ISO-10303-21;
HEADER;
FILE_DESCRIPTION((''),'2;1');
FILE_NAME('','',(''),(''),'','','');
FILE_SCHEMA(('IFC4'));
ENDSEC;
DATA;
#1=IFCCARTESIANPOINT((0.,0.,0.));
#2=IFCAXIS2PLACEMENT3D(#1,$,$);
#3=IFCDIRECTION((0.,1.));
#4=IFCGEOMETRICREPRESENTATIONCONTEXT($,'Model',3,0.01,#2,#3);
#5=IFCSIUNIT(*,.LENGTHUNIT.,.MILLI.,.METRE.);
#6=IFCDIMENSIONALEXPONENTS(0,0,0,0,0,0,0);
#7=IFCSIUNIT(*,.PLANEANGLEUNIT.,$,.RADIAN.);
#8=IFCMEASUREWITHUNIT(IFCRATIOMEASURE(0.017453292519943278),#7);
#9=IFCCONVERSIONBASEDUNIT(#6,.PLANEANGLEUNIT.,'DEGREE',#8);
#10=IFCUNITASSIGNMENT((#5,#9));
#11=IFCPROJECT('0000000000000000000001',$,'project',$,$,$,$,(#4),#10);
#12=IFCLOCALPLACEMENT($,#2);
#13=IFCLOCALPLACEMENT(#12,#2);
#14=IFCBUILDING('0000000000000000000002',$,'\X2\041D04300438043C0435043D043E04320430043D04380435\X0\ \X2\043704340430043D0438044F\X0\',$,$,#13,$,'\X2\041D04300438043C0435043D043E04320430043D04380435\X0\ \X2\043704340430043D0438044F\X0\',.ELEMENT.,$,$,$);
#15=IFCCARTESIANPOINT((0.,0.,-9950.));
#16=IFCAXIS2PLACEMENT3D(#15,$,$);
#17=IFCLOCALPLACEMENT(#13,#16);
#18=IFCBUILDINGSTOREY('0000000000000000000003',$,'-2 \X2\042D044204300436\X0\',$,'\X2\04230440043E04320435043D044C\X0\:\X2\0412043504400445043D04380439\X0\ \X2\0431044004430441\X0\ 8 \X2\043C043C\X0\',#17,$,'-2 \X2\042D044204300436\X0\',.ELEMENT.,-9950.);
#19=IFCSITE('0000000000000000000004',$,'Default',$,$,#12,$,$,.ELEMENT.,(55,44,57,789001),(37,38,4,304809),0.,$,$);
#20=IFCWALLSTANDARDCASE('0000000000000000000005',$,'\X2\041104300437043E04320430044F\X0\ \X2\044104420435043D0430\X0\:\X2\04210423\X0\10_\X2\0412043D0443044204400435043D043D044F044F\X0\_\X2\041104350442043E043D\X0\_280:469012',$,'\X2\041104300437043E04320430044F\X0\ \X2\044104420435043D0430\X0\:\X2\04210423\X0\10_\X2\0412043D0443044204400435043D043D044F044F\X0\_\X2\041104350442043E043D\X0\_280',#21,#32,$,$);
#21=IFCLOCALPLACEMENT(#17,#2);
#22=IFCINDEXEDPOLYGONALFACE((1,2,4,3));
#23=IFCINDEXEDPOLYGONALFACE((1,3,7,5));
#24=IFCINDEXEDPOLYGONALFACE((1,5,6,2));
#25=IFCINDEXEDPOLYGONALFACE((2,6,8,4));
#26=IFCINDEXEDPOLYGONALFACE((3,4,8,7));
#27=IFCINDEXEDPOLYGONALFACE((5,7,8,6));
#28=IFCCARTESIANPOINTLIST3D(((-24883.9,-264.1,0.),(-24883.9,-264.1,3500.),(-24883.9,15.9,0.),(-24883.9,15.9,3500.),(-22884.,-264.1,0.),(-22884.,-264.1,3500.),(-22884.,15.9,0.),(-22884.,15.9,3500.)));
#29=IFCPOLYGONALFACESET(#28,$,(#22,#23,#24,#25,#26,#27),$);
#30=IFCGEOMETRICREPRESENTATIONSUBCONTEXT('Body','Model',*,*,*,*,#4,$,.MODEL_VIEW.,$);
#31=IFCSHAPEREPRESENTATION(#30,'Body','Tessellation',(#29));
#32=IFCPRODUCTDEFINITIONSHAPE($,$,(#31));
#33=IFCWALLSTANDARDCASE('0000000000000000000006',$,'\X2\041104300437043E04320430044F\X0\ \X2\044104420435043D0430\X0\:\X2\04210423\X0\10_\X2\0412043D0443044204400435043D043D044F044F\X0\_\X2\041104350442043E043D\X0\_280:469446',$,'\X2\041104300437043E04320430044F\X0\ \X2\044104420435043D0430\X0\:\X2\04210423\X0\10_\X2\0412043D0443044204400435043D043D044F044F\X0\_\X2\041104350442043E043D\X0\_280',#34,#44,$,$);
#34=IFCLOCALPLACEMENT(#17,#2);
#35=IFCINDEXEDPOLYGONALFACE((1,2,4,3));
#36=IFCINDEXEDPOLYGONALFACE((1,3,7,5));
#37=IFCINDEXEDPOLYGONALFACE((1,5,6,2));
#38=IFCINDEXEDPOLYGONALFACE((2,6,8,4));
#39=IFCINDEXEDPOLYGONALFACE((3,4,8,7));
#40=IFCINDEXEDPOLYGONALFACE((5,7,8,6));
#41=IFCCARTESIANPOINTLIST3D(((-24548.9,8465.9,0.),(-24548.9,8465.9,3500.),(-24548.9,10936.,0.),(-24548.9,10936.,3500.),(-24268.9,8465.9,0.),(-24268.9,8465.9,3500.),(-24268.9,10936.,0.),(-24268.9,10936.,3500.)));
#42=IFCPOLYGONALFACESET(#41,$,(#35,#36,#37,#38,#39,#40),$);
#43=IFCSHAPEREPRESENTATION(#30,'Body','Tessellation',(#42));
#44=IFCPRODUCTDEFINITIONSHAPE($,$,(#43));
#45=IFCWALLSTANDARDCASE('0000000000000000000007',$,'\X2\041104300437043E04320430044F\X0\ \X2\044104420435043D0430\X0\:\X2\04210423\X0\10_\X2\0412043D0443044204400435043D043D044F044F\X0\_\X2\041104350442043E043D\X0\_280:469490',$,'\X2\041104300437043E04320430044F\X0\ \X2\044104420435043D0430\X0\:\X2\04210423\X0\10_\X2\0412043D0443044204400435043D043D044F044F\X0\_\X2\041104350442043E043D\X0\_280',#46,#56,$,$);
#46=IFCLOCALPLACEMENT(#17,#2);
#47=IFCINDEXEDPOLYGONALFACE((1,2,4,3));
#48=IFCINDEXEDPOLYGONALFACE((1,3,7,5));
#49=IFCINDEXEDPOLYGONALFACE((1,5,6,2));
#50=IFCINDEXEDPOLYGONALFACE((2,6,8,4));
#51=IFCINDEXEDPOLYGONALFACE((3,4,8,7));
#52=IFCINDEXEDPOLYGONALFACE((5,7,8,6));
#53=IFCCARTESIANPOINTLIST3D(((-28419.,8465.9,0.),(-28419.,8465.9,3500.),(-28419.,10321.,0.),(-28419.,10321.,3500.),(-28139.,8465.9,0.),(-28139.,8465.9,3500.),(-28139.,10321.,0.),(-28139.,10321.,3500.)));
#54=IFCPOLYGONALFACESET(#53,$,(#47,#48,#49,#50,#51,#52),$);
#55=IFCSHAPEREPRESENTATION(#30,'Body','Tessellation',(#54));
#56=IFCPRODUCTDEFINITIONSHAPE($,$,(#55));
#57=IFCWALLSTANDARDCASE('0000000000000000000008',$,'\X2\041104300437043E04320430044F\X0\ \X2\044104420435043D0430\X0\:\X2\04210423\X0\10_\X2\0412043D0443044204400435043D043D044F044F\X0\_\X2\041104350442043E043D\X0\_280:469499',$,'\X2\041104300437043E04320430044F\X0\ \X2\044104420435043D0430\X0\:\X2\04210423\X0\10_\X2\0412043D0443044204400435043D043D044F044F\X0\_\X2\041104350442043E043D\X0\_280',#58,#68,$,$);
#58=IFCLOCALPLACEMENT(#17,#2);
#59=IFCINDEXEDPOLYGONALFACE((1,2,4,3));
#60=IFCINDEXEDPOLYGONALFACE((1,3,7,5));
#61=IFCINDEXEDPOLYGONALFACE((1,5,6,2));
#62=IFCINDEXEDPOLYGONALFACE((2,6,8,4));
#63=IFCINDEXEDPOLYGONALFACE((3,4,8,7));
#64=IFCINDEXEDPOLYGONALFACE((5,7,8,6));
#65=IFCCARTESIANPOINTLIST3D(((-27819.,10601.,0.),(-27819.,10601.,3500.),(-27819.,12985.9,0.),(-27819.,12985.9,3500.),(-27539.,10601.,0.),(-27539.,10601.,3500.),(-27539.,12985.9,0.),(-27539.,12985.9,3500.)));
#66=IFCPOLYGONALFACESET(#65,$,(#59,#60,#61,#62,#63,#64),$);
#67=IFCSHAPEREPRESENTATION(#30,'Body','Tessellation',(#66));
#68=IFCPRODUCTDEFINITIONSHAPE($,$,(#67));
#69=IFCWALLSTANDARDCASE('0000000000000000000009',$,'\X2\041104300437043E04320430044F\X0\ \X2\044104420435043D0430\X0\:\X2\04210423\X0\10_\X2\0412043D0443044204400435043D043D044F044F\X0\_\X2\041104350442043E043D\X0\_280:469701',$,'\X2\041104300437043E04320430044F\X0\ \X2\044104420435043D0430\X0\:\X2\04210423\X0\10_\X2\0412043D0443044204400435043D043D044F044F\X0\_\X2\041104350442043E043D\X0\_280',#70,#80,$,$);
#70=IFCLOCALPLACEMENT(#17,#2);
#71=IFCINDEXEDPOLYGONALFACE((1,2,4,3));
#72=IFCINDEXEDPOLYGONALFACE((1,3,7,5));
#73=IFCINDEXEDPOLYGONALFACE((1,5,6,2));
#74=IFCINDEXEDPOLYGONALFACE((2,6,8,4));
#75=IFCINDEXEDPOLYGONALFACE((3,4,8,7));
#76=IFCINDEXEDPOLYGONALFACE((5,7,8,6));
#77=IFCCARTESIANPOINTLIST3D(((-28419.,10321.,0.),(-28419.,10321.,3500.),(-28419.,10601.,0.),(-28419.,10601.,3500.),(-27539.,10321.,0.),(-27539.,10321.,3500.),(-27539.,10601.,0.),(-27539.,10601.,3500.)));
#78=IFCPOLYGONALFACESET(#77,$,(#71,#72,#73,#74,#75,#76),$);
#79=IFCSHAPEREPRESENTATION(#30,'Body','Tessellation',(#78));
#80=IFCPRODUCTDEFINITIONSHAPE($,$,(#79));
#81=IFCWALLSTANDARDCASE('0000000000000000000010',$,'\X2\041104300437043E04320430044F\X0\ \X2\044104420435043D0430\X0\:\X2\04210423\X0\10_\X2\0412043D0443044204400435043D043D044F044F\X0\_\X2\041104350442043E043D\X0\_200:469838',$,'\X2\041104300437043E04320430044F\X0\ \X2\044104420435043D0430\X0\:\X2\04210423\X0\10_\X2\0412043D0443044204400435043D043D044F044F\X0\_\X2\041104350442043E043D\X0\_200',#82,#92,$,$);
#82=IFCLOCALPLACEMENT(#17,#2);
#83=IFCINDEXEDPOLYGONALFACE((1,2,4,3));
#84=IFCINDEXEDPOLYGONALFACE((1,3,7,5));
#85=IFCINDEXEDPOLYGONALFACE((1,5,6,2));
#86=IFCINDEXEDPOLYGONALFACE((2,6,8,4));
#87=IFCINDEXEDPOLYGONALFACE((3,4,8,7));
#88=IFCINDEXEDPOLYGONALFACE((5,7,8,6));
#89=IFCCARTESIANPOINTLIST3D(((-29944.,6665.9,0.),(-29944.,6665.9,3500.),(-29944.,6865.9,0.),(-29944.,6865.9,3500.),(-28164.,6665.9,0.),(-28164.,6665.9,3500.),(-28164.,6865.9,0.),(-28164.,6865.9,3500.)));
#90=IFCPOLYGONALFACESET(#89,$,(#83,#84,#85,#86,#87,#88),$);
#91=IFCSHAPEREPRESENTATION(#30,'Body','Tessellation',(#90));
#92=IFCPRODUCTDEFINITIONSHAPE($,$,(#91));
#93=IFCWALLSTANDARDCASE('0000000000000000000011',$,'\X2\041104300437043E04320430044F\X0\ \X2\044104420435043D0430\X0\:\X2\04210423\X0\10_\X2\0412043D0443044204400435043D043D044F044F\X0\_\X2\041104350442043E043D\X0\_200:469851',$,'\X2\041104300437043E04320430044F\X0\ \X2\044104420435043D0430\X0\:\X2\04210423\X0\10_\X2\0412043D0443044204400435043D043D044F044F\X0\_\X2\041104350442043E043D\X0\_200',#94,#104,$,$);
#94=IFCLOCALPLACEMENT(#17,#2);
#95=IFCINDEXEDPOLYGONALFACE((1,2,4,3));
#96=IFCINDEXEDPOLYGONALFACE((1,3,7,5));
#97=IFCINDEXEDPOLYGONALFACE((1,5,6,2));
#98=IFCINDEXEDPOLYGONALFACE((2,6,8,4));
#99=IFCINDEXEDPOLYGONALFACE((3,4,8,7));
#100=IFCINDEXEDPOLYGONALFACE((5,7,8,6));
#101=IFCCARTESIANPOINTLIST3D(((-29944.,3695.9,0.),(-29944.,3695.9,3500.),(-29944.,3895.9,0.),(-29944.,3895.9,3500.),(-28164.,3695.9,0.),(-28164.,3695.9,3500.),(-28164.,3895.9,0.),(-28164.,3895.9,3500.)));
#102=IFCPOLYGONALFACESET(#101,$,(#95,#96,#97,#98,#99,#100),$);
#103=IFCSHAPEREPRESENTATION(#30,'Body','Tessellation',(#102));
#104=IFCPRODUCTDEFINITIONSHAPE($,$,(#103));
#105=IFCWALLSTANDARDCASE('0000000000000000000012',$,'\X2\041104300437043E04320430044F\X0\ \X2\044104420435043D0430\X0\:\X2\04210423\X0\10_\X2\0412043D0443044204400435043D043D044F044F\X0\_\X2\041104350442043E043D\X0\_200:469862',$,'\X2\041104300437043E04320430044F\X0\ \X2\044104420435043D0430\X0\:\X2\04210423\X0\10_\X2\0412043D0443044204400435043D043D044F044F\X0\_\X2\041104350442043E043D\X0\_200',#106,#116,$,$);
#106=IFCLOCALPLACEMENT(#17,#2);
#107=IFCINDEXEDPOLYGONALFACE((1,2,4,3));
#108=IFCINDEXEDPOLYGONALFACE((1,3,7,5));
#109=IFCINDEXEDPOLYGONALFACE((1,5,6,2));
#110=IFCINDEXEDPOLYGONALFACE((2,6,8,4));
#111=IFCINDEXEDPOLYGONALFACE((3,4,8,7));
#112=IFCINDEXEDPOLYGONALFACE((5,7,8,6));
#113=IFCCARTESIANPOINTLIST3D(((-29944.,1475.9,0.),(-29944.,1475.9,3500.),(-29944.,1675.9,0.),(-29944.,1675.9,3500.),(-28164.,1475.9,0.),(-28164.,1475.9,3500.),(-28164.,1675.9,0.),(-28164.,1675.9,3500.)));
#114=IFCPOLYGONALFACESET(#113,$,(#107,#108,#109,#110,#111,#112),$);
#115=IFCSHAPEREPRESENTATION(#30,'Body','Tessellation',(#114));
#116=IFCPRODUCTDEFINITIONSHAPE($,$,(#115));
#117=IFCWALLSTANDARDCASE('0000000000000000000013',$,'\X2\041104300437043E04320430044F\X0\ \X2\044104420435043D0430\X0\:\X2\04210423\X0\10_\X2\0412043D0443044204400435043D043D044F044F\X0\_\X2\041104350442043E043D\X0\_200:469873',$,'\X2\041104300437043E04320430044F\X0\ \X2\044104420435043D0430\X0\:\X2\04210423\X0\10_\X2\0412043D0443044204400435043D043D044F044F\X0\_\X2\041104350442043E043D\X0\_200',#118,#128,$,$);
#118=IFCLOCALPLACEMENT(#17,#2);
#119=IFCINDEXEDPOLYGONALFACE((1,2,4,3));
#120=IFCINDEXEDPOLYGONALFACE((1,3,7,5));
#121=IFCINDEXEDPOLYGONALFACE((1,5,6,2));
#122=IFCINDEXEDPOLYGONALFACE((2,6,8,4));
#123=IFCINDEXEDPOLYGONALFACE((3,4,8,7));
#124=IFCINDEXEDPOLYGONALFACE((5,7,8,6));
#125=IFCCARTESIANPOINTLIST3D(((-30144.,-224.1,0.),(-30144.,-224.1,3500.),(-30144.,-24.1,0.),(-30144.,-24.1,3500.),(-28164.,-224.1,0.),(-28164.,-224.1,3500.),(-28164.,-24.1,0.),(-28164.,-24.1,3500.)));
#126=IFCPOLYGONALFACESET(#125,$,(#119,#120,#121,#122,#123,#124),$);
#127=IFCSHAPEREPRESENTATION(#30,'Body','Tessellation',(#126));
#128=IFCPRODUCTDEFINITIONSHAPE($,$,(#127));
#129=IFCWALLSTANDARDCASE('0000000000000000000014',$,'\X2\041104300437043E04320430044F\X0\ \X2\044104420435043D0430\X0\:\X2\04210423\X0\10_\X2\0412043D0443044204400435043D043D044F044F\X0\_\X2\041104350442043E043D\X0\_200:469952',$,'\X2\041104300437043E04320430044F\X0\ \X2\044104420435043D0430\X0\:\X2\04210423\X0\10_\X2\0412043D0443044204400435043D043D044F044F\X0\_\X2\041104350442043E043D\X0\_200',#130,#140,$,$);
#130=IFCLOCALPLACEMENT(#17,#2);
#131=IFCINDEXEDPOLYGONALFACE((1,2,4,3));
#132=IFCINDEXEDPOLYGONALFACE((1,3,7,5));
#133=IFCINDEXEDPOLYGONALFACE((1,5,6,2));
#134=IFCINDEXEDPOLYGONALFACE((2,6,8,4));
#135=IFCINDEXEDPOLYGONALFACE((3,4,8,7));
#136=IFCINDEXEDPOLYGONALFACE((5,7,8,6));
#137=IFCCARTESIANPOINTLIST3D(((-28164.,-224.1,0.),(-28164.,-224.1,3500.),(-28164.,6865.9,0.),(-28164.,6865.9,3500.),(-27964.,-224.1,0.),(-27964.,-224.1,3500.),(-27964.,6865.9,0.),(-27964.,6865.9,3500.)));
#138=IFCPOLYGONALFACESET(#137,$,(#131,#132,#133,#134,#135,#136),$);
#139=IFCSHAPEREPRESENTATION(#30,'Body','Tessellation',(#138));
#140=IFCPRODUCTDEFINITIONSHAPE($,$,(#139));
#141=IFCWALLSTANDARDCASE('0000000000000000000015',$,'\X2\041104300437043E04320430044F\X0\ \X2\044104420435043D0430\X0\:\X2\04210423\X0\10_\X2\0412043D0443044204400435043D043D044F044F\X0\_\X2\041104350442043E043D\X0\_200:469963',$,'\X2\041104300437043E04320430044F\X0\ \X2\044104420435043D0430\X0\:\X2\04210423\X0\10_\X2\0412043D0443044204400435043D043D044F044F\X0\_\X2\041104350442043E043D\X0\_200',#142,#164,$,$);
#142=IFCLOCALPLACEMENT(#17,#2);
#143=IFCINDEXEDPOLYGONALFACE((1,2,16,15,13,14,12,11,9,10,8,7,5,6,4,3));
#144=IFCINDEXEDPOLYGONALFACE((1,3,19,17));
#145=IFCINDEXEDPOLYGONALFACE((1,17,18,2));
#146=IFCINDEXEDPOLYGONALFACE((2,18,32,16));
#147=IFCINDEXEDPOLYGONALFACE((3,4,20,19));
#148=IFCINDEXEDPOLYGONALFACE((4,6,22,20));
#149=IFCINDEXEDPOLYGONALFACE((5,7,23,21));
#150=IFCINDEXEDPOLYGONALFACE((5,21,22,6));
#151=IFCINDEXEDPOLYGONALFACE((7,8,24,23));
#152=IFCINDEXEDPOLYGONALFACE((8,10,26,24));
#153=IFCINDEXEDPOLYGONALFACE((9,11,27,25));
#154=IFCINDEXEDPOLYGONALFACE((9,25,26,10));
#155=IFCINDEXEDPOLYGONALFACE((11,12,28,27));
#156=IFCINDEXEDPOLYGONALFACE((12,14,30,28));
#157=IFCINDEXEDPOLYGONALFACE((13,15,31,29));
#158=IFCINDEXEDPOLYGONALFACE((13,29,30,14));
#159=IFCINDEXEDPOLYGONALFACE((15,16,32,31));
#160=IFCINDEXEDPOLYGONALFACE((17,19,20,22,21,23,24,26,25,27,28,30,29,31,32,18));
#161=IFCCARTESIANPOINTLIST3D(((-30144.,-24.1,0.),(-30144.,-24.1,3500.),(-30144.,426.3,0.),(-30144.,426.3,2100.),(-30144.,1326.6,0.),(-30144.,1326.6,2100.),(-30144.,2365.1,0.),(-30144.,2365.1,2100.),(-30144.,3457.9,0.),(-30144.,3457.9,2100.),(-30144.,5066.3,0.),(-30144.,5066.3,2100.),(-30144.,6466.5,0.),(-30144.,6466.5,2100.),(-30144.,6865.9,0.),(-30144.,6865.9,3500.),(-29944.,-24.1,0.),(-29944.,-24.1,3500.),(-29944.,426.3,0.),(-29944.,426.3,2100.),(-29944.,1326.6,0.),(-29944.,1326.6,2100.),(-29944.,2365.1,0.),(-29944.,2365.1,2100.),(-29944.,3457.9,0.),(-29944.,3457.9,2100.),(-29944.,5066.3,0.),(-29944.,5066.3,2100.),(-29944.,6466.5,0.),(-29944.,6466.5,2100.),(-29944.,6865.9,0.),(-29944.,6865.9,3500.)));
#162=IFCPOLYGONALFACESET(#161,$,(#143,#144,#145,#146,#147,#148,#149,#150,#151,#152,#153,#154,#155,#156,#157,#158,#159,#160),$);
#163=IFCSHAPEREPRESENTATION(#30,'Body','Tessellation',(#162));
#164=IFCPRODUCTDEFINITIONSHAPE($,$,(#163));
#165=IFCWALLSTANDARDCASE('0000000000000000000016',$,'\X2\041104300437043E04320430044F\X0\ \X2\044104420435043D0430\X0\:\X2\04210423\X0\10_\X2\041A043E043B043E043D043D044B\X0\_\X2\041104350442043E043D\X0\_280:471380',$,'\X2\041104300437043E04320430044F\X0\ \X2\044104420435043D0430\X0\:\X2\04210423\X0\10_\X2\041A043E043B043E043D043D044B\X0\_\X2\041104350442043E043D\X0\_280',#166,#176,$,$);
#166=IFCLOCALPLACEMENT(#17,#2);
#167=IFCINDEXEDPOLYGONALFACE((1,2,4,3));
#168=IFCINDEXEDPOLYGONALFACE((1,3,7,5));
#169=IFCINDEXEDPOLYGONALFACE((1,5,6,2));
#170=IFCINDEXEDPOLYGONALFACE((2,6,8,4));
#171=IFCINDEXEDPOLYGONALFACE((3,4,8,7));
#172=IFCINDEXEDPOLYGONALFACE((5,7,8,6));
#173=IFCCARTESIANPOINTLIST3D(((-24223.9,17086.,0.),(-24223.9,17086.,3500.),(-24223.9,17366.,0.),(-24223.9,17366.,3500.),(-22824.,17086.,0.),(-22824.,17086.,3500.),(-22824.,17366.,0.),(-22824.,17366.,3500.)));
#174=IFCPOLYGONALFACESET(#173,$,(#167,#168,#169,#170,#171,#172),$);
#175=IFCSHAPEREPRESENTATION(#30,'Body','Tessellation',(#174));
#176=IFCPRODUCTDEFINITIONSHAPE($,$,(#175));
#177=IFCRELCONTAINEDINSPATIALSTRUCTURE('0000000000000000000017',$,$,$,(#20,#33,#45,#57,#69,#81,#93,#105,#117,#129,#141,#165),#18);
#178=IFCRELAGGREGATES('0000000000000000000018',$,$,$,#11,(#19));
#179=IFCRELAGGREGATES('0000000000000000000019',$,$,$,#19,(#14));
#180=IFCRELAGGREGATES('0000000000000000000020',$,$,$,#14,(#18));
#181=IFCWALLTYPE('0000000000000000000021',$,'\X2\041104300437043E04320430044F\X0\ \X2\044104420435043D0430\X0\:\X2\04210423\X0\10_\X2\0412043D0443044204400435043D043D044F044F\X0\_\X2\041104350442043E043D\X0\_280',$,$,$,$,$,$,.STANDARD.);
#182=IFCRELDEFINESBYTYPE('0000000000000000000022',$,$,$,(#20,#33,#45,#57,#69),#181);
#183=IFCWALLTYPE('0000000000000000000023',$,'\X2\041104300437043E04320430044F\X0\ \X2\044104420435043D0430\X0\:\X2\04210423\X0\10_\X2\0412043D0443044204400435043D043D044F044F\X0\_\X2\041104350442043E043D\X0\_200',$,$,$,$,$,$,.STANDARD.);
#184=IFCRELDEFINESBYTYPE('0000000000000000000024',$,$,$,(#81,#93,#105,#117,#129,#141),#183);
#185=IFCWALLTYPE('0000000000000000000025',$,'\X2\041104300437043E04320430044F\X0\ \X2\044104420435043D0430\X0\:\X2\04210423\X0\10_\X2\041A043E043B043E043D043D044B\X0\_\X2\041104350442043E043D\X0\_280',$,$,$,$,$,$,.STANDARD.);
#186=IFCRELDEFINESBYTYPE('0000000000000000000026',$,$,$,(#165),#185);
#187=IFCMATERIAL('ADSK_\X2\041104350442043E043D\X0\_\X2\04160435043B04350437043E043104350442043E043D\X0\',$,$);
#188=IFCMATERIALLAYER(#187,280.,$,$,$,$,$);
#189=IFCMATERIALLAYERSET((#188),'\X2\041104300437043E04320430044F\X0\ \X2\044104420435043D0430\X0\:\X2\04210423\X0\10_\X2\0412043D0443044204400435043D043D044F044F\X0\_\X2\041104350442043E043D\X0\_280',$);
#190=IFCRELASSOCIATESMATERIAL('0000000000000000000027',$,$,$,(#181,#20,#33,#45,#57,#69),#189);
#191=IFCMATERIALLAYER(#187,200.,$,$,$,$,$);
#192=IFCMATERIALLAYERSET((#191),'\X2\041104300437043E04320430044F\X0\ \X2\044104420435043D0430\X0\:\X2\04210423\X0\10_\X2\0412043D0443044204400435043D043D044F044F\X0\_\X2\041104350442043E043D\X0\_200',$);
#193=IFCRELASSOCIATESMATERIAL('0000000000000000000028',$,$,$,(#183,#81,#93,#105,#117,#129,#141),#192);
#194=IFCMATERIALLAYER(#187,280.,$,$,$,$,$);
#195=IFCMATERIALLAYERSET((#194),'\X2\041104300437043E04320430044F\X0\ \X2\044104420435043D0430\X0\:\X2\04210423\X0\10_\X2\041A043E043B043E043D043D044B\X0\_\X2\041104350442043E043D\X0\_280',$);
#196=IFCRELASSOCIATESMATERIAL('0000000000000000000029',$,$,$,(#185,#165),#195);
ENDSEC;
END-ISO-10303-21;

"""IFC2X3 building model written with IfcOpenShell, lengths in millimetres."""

from ifc_helpers import new_model, entity, si_unit, converted_unit, direction, frame, frame_2d, origin, place, context, subcontext, project, spatial, rectangle, extrude, material, layer, layer_set, layer_usage, type_object, element, save


model = new_model("IFC2X3")

# Units and contexts
model_context = context("Model", 3, precision=0.01, world=origin(), true_north=direction((0.0, 1.0)))
body_context = subcontext(model_context, "Body", "Model", "MODEL_VIEW")
ifc_project = project(units=[si_unit("LENGTHUNIT", "METRE", prefix="MILLI"), converted_unit("PLANEANGLEUNIT", "DEGREE", entity("IfcRatioMeasure", 0.017453292519943278), si_unit("PLANEANGLEUNIT", "RADIAN"), dimensions=[0, 0, 0, 0, 0, 0, 0])], contexts=[model_context])

# Site, building, storey
site_placement = place(None, origin())
site = spatial("IfcSite", under=ifc_project, at=site_placement, Name="Default", CompositionType="ELEMENT", RefLatitude=(55, 44, 57, 789001), RefLongitude=(37, 38, 4, 304809), RefElevation=0.0)
building_placement = place(site_placement, origin())
building = spatial("IfcBuilding", under=site, at=building_placement, Name="Наименование здания", LongName="Наименование здания", CompositionType="ELEMENT")
storey_placement = place(building_placement, frame((0.0, 0.0, -9950.0)))
storey = spatial("IfcBuildingStorey", under=building, at=storey_placement, Name="-2 Этаж", ObjectType="Уровень:Верхний брус 8 мм", LongName="-2 Этаж", CompositionType="ELEMENT", Elevation=-9950.0)

# Walls
ifc_material_1 = material(Name="ADSK_Бетон_Железобетон")
ifc_layer_1 = layer(ifc_material_1, 280.0)
ifc_layer_set_1 = layer_set([ifc_layer_1], Name="Базовая стена:СУ10_Внутренняя_Бетон_280")
ifc_layer_usage_1 = layer_usage(ifc_layer_set_1, "AXIS2", "NEGATIVE", 140.0)
wall_type_1 = type_object("IfcWallType", Name="Базовая стена:СУ10_Внутренняя_Бетон_280", PredefinedType="STANDARD", material=ifc_layer_set_1)
wall_1_placement = place(storey_placement, frame((-22884.0, -124.1, 0.0), z_axis=(0.0, 0.0, 1.0), x_axis=(-1.0, 0.0, 0.0)))
element("IfcWallStandardCase", 1, at=wall_1_placement, inside=storey, type_object=wall_type_1, material=ifc_layer_usage_1, Name="Базовая стена:СУ10_Внутренняя_Бетон_280:469012", ObjectType="Базовая стена:СУ10_Внутренняя_Бетон_280", context=body_context, shape_type="SweptSolid", body=[
    extrude(rectangle(XDim=2000.0, YDim=280.0, at=frame_2d((1000.0, 0.0), x_axis=(-1.0, 0.0))), origin(), (0.0, 0.0, 1.0), 3500.0),
])
wall_2_placement = place(storey_placement, frame((-24408.9, 10936.0, 0.0), z_axis=(0.0, 0.0, 1.0), x_axis=(0.0, -1.0, 0.0)))
element("IfcWallStandardCase", 2, at=wall_2_placement, inside=storey, type_object=wall_type_1, material=ifc_layer_usage_1, Name="Базовая стена:СУ10_Внутренняя_Бетон_280:469446", ObjectType="Базовая стена:СУ10_Внутренняя_Бетон_280", context=body_context, shape_type="SweptSolid", body=[
    extrude(rectangle(XDim=2470.0, YDim=280.0, at=frame_2d((1235.0, 0.0), x_axis=(-1.0, 0.0))), origin(), (0.0, 0.0, 1.0), 3500.0),
])
wall_3_placement = place(storey_placement, frame((-28279.0, 10321.0, 0.0), z_axis=(0.0, 0.0, 1.0), x_axis=(0.0, -1.0, 0.0)))
element("IfcWallStandardCase", 3, at=wall_3_placement, inside=storey, type_object=wall_type_1, material=ifc_layer_usage_1, Name="Базовая стена:СУ10_Внутренняя_Бетон_280:469490", ObjectType="Базовая стена:СУ10_Внутренняя_Бетон_280", context=body_context, shape_type="SweptSolid", body=[
    extrude(rectangle(XDim=1855.0, YDim=280.0, at=frame_2d((927.5, 0.0), x_axis=(-1.0, 0.0))), origin(), (0.0, 0.0, 1.0), 3500.0),
])
wall_4_placement = place(storey_placement, frame((-27679.0, 12985.9, 0.0), z_axis=(0.0, 0.0, 1.0), x_axis=(0.0, -1.0, 0.0)))
element("IfcWallStandardCase", 4, at=wall_4_placement, inside=storey, type_object=wall_type_1, material=ifc_layer_usage_1, Name="Базовая стена:СУ10_Внутренняя_Бетон_280:469499", ObjectType="Базовая стена:СУ10_Внутренняя_Бетон_280", context=body_context, shape_type="SweptSolid", body=[
    extrude(rectangle(XDim=2384.9, YDim=280.0, at=frame_2d((1192.5, 0.0), x_axis=(-1.0, 0.0))), origin(), (0.0, 0.0, 1.0), 3500.0),
])
wall_5_placement = place(storey_placement, frame((-27539.0, 10461.0, 0.0), z_axis=(0.0, 0.0, 1.0), x_axis=(-1.0, 0.0, 0.0)))
element("IfcWallStandardCase", 5, at=wall_5_placement, inside=storey, type_object=wall_type_1, material=ifc_layer_usage_1, Name="Базовая стена:СУ10_Внутренняя_Бетон_280:469701", ObjectType="Базовая стена:СУ10_Внутренняя_Бетон_280", context=body_context, shape_type="SweptSolid", body=[
    extrude(rectangle(XDim=880.0, YDim=280.0, at=frame_2d((440.0, 0.0), x_axis=(-1.0, 0.0))), origin(), (0.0, 0.0, 1.0), 3500.0),
])
ifc_layer_2 = layer(ifc_material_1, 200.0)
ifc_layer_set_2 = layer_set([ifc_layer_2], Name="Базовая стена:СУ10_Внутренняя_Бетон_200")
ifc_layer_usage_2 = layer_usage(ifc_layer_set_2, "AXIS2", "NEGATIVE", 100.0)
wall_type_2 = type_object("IfcWallType", Name="Базовая стена:СУ10_Внутренняя_Бетон_200", PredefinedType="STANDARD", material=ifc_layer_set_2)
wall_6_placement = place(storey_placement, frame((-28164.0, 6765.9, 0.0), z_axis=(0.0, 0.0, 1.0), x_axis=(-1.0, 0.0, 0.0)))
element("IfcWallStandardCase", 6, at=wall_6_placement, inside=storey, type_object=wall_type_2, material=ifc_layer_usage_2, Name="Базовая стена:СУ10_Внутренняя_Бетон_200:469838", ObjectType="Базовая стена:СУ10_Внутренняя_Бетон_200", context=body_context, shape_type="SweptSolid", body=[
    extrude(rectangle(XDim=1780.0, YDim=200.0, at=frame_2d((890.0, 0.0), x_axis=(-1.0, 0.0))), origin(), (0.0, 0.0, 1.0), 3500.0),
])
wall_7_placement = place(storey_placement, frame((-28164.0, 3795.9, 0.0), z_axis=(0.0, 0.0, 1.0), x_axis=(-1.0, 0.0, 0.0)))
element("IfcWallStandardCase", 7, at=wall_7_placement, inside=storey, type_object=wall_type_2, material=ifc_layer_usage_2, Name="Базовая стена:СУ10_Внутренняя_Бетон_200:469851", ObjectType="Базовая стена:СУ10_Внутренняя_Бетон_200", context=body_context, shape_type="SweptSolid", body=[
    extrude(rectangle(XDim=1780.0, YDim=200.0, at=frame_2d((890.0, 0.0), x_axis=(-1.0, 0.0))), origin(), (0.0, 0.0, 1.0), 3500.0),
])
wall_8_placement = place(storey_placement, frame((-28164.0, 1575.9, 0.0), z_axis=(0.0, 0.0, 1.0), x_axis=(-1.0, 0.0, 0.0)))
element("IfcWallStandardCase", 8, at=wall_8_placement, inside=storey, type_object=wall_type_2, material=ifc_layer_usage_2, Name="Базовая стена:СУ10_Внутренняя_Бетон_200:469862", ObjectType="Базовая стена:СУ10_Внутренняя_Бетон_200", context=body_context, shape_type="SweptSolid", body=[
    extrude(rectangle(XDim=1780.0, YDim=200.0, at=frame_2d((890.0, 0.0), x_axis=(-1.0, 0.0))), origin(), (0.0, 0.0, 1.0), 3500.0),
])
wall_9_placement = place(storey_placement, frame((-28164.0, -124.1, 0.0), z_axis=(0.0, 0.0, 1.0), x_axis=(-1.0, 0.0, 0.0)))
element("IfcWallStandardCase", 9, at=wall_9_placement, inside=storey, type_object=wall_type_2, material=ifc_layer_usage_2, Name="Базовая стена:СУ10_Внутренняя_Бетон_200:469873", ObjectType="Базовая стена:СУ10_Внутренняя_Бетон_200", context=body_context, shape_type="SweptSolid", body=[
    extrude(rectangle(XDim=1980.0, YDim=200.0, at=frame_2d((990.0, 0.0), x_axis=(-1.0, 0.0))), origin(), (0.0, 0.0, 1.0), 3500.0),
])
wall_10_placement = place(storey_placement, frame((-28064.0, 6865.9, 0.0), z_axis=(0.0, 0.0, 1.0), x_axis=(0.0, -1.0, 0.0)))
element("IfcWallStandardCase", 10, at=wall_10_placement, inside=storey, type_object=wall_type_2, material=ifc_layer_usage_2, Name="Базовая стена:СУ10_Внутренняя_Бетон_200:469952", ObjectType="Базовая стена:СУ10_Внутренняя_Бетон_200", context=body_context, shape_type="SweptSolid", body=[
    extrude(rectangle(XDim=7090.0, YDim=200.0, at=frame_2d((3545.0, 0.0), x_axis=(-1.0, 0.0))), origin(), (0.0, 0.0, 1.0), 3500.0),
])

# Wall, openings
wall_11_placement = place(storey_placement, frame((-30044.0, 6865.9, 0.0), z_axis=(0.0, 0.0, 1.0), x_axis=(0.0, -1.0, 0.0)))
wall_11 = element("IfcWallStandardCase", 11, at=wall_11_placement, inside=storey, type_object=wall_type_2, material=ifc_layer_usage_2, Name="Базовая стена:СУ10_Внутренняя_Бетон_200:469963", ObjectType="Базовая стена:СУ10_Внутренняя_Бетон_200", context=body_context, shape_type="SweptSolid", body=[
    extrude(rectangle(XDim=6890.0, YDim=200.0, at=frame_2d((3445.0, 0.0), x_axis=(-1.0, 0.0))), origin(), (0.0, 0.0, 1.0), 3500.0),
])
opening_1_placement = place(wall_11_placement, origin())
element("IfcOpeningElement", 12, at=opening_1_placement, cuts=wall_11, ObjectType="Opening", context=body_context, shape_type="SweptSolid", body=[
    extrude(rectangle(XDim=2100.0, YDim=1400.2, at=frame_2d((0.0, 0.0), x_axis=(1.0, 0.0))), frame((1099.5, -100.0, 1050.0), z_axis=(0.0, 1.0, 0.0), x_axis=(0.0, 0.0, -1.0)), (0.0, 0.0, 1.0), 200.0),
])
opening_2_placement = place(wall_11_placement, origin())
element("IfcOpeningElement", 13, at=opening_2_placement, cuts=wall_11, ObjectType="Opening", context=body_context, shape_type="SweptSolid", body=[
    extrude(rectangle(XDim=2100.0, YDim=1092.8, at=frame_2d((0.0, 0.0), x_axis=(1.0, 0.0))), frame((3954.4, -100.0, 1050.0), z_axis=(0.0, 1.0, 0.0), x_axis=(0.0, 0.0, -1.0)), (0.0, 0.0, 1.0), 200.0),
])
opening_3_placement = place(wall_11_placement, origin())
element("IfcOpeningElement", 14, at=opening_3_placement, cuts=wall_11, ObjectType="Opening", context=body_context, shape_type="SweptSolid", body=[
    extrude(rectangle(XDim=2100.0, YDim=900.3, at=frame_2d((0.0, 0.0), x_axis=(1.0, 0.0))), frame((5989.4, -100.0, 1050.0), z_axis=(0.0, 1.0, 0.0), x_axis=(0.0, 0.0, -1.0)), (0.0, 0.0, 1.0), 200.0),
])

# Wall
ifc_layer_3 = layer(ifc_material_1, 280.0)
ifc_layer_set_3 = layer_set([ifc_layer_3], Name="Базовая стена:СУ10_Колонны_Бетон_280")
ifc_layer_usage_3 = layer_usage(ifc_layer_set_3, "AXIS2", "NEGATIVE", 140.0)
wall_type_3 = type_object("IfcWallType", Name="Базовая стена:СУ10_Колонны_Бетон_280", PredefinedType="STANDARD", material=ifc_layer_set_3)
wall_12_placement = place(storey_placement, frame((-22824.0, 17226.0, 0.0), z_axis=(0.0, 0.0, 1.0), x_axis=(-1.0, 0.0, 0.0)))
element("IfcWallStandardCase", 15, at=wall_12_placement, inside=storey, type_object=wall_type_3, material=ifc_layer_usage_3, Name="Базовая стена:СУ10_Колонны_Бетон_280:471380", ObjectType="Базовая стена:СУ10_Колонны_Бетон_280", context=body_context, shape_type="SweptSolid", body=[
    extrude(rectangle(XDim=1399.9, YDim=280.0, at=frame_2d((700.0, 0.0), x_axis=(-1.0, 0.0))), origin(), (0.0, 0.0, 1.0), 3500.0),
])

save(model, "model.ifc")
